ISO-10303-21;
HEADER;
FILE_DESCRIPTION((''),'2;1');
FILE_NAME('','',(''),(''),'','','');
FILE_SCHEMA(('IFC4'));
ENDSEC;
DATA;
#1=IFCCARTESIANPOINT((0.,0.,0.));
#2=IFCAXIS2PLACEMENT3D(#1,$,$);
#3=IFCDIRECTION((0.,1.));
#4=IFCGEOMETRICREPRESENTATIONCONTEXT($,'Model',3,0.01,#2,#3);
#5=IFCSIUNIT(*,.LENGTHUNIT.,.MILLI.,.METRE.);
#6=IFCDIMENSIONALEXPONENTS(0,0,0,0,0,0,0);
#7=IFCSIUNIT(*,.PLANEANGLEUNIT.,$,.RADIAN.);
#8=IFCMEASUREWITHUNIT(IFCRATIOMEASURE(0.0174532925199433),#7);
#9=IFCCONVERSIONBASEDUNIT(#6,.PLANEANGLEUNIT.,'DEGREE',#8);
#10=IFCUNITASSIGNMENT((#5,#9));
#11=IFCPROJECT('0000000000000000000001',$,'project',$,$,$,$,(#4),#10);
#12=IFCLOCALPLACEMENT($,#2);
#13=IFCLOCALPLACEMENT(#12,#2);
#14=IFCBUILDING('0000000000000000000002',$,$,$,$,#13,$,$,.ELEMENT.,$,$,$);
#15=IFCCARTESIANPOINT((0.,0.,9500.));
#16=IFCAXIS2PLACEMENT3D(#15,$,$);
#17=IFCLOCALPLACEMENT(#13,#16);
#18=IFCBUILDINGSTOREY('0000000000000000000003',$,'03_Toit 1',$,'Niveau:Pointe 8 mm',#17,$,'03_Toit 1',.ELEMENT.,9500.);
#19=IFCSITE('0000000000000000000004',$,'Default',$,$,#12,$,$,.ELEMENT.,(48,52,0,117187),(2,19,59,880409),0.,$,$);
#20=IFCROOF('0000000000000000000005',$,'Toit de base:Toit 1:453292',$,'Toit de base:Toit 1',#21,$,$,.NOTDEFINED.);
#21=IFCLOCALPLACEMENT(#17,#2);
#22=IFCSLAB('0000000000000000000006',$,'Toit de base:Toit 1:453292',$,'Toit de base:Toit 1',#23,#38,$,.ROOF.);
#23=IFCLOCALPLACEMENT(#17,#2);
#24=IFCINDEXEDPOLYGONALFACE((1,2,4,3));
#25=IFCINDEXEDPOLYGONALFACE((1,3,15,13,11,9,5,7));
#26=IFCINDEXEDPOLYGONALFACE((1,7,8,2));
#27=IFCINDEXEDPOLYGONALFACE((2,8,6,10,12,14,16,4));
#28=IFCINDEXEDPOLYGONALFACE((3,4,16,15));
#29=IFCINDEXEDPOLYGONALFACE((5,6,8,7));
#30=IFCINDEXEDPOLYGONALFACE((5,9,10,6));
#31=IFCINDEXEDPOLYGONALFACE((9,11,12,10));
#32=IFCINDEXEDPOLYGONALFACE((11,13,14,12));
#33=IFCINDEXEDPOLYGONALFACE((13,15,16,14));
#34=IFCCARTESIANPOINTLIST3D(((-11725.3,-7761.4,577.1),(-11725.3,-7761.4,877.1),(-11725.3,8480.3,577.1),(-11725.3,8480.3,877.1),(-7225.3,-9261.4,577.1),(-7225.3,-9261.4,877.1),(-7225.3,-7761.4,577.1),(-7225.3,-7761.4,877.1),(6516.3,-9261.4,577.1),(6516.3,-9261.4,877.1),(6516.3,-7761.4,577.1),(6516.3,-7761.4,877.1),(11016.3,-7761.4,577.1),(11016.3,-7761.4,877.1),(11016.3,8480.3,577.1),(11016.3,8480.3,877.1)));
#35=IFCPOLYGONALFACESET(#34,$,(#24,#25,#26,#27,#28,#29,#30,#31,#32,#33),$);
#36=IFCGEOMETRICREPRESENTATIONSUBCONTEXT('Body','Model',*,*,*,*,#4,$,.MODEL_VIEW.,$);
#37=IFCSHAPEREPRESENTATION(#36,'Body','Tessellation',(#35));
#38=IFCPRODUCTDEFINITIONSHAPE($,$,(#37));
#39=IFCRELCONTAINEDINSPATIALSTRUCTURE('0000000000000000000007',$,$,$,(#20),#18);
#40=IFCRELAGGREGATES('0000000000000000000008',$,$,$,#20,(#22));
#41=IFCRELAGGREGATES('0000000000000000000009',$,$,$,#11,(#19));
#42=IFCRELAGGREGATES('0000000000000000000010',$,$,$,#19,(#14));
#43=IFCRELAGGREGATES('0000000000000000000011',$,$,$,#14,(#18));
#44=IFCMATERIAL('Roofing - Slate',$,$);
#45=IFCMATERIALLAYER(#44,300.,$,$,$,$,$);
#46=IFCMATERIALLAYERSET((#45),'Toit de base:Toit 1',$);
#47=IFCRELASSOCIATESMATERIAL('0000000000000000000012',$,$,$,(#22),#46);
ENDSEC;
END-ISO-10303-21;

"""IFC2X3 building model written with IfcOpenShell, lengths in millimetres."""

from ifc_helpers import new_model, entity, si_unit, converted_unit, direction, frame, origin, place, context, subcontext, project, spatial, polyline, outline, extrude, material, layer, layer_set, element, aggregate, save


model = new_model("IFC2X3")

# Units and contexts
model_context = context("Model", 3, precision=0.01, world=origin(), true_north=direction((0.0, 1.0)))
body_context = subcontext(model_context, "Body", "Model", "MODEL_VIEW")
ifc_project = project(units=[si_unit("LENGTHUNIT", "METRE", prefix="MILLI"), converted_unit("PLANEANGLEUNIT", "DEGREE", entity("IfcRatioMeasure", 0.0174532925199433), si_unit("PLANEANGLEUNIT", "RADIAN"), dimensions=[0, 0, 0, 0, 0, 0, 0])], contexts=[model_context])

# Site, building, storey
site_placement = place(None, origin())
site = spatial("IfcSite", under=ifc_project, at=site_placement, Name="Default", CompositionType="ELEMENT", RefLatitude=(48, 52, 0, 117187), RefLongitude=(2, 19, 59, 880409), RefElevation=0.0)
building_placement = place(site_placement, origin())
building = spatial("IfcBuilding", under=site, at=building_placement, CompositionType="ELEMENT")
storey_placement = place(building_placement, frame((0.0, 0.0, 9500.0)))
storey = spatial("IfcBuildingStorey", under=building, at=storey_placement, Name="03_Toit 1", ObjectType="Niveau:Pointe 8 mm", LongName="03_Toit 1", CompositionType="ELEMENT", Elevation=9500.0)

# Roof, slab
roof_placement = place(storey_placement, frame((-11725.3, -9261.4, 577.1)))
roof = element("IfcRoof", 1, at=roof_placement, inside=storey, Name="Toit de base:Toit 1:453292", ObjectType="Toit de base:Toit 1", ShapeType="NOTDEFINED")
ifc_material = material(Name="Roofing - Slate")
ifc_layer = layer(ifc_material, 300.0)
ifc_layer_set = layer_set([ifc_layer], Name="Toit de base:Toit 1")
slab_placement = place(roof_placement, origin())
slab = element("IfcSlab", 2, at=slab_placement, material=ifc_layer_set, Name="Toit de base:Toit 1:453292", ObjectType="Toit de base:Toit 1", PredefinedType="ROOF", context=body_context, shape_type="SweptSolid", body=[
    extrude(outline(polyline([(-11370.8, -7370.8), (-6870.8, -7370.8), (-6870.8, -8870.8), (6870.8, -8870.8), (6870.8, -7370.8), (11370.8, -7370.8), (11370.8, 8870.8), (-11370.8, 8870.8), (-11370.8, -7370.8)])), frame((11370.8, 8870.8, 0.0)), (0.0, 0.0, 1.0), 300.0),
])
aggregate(roof, [slab])

save(model, "model.ifc")
